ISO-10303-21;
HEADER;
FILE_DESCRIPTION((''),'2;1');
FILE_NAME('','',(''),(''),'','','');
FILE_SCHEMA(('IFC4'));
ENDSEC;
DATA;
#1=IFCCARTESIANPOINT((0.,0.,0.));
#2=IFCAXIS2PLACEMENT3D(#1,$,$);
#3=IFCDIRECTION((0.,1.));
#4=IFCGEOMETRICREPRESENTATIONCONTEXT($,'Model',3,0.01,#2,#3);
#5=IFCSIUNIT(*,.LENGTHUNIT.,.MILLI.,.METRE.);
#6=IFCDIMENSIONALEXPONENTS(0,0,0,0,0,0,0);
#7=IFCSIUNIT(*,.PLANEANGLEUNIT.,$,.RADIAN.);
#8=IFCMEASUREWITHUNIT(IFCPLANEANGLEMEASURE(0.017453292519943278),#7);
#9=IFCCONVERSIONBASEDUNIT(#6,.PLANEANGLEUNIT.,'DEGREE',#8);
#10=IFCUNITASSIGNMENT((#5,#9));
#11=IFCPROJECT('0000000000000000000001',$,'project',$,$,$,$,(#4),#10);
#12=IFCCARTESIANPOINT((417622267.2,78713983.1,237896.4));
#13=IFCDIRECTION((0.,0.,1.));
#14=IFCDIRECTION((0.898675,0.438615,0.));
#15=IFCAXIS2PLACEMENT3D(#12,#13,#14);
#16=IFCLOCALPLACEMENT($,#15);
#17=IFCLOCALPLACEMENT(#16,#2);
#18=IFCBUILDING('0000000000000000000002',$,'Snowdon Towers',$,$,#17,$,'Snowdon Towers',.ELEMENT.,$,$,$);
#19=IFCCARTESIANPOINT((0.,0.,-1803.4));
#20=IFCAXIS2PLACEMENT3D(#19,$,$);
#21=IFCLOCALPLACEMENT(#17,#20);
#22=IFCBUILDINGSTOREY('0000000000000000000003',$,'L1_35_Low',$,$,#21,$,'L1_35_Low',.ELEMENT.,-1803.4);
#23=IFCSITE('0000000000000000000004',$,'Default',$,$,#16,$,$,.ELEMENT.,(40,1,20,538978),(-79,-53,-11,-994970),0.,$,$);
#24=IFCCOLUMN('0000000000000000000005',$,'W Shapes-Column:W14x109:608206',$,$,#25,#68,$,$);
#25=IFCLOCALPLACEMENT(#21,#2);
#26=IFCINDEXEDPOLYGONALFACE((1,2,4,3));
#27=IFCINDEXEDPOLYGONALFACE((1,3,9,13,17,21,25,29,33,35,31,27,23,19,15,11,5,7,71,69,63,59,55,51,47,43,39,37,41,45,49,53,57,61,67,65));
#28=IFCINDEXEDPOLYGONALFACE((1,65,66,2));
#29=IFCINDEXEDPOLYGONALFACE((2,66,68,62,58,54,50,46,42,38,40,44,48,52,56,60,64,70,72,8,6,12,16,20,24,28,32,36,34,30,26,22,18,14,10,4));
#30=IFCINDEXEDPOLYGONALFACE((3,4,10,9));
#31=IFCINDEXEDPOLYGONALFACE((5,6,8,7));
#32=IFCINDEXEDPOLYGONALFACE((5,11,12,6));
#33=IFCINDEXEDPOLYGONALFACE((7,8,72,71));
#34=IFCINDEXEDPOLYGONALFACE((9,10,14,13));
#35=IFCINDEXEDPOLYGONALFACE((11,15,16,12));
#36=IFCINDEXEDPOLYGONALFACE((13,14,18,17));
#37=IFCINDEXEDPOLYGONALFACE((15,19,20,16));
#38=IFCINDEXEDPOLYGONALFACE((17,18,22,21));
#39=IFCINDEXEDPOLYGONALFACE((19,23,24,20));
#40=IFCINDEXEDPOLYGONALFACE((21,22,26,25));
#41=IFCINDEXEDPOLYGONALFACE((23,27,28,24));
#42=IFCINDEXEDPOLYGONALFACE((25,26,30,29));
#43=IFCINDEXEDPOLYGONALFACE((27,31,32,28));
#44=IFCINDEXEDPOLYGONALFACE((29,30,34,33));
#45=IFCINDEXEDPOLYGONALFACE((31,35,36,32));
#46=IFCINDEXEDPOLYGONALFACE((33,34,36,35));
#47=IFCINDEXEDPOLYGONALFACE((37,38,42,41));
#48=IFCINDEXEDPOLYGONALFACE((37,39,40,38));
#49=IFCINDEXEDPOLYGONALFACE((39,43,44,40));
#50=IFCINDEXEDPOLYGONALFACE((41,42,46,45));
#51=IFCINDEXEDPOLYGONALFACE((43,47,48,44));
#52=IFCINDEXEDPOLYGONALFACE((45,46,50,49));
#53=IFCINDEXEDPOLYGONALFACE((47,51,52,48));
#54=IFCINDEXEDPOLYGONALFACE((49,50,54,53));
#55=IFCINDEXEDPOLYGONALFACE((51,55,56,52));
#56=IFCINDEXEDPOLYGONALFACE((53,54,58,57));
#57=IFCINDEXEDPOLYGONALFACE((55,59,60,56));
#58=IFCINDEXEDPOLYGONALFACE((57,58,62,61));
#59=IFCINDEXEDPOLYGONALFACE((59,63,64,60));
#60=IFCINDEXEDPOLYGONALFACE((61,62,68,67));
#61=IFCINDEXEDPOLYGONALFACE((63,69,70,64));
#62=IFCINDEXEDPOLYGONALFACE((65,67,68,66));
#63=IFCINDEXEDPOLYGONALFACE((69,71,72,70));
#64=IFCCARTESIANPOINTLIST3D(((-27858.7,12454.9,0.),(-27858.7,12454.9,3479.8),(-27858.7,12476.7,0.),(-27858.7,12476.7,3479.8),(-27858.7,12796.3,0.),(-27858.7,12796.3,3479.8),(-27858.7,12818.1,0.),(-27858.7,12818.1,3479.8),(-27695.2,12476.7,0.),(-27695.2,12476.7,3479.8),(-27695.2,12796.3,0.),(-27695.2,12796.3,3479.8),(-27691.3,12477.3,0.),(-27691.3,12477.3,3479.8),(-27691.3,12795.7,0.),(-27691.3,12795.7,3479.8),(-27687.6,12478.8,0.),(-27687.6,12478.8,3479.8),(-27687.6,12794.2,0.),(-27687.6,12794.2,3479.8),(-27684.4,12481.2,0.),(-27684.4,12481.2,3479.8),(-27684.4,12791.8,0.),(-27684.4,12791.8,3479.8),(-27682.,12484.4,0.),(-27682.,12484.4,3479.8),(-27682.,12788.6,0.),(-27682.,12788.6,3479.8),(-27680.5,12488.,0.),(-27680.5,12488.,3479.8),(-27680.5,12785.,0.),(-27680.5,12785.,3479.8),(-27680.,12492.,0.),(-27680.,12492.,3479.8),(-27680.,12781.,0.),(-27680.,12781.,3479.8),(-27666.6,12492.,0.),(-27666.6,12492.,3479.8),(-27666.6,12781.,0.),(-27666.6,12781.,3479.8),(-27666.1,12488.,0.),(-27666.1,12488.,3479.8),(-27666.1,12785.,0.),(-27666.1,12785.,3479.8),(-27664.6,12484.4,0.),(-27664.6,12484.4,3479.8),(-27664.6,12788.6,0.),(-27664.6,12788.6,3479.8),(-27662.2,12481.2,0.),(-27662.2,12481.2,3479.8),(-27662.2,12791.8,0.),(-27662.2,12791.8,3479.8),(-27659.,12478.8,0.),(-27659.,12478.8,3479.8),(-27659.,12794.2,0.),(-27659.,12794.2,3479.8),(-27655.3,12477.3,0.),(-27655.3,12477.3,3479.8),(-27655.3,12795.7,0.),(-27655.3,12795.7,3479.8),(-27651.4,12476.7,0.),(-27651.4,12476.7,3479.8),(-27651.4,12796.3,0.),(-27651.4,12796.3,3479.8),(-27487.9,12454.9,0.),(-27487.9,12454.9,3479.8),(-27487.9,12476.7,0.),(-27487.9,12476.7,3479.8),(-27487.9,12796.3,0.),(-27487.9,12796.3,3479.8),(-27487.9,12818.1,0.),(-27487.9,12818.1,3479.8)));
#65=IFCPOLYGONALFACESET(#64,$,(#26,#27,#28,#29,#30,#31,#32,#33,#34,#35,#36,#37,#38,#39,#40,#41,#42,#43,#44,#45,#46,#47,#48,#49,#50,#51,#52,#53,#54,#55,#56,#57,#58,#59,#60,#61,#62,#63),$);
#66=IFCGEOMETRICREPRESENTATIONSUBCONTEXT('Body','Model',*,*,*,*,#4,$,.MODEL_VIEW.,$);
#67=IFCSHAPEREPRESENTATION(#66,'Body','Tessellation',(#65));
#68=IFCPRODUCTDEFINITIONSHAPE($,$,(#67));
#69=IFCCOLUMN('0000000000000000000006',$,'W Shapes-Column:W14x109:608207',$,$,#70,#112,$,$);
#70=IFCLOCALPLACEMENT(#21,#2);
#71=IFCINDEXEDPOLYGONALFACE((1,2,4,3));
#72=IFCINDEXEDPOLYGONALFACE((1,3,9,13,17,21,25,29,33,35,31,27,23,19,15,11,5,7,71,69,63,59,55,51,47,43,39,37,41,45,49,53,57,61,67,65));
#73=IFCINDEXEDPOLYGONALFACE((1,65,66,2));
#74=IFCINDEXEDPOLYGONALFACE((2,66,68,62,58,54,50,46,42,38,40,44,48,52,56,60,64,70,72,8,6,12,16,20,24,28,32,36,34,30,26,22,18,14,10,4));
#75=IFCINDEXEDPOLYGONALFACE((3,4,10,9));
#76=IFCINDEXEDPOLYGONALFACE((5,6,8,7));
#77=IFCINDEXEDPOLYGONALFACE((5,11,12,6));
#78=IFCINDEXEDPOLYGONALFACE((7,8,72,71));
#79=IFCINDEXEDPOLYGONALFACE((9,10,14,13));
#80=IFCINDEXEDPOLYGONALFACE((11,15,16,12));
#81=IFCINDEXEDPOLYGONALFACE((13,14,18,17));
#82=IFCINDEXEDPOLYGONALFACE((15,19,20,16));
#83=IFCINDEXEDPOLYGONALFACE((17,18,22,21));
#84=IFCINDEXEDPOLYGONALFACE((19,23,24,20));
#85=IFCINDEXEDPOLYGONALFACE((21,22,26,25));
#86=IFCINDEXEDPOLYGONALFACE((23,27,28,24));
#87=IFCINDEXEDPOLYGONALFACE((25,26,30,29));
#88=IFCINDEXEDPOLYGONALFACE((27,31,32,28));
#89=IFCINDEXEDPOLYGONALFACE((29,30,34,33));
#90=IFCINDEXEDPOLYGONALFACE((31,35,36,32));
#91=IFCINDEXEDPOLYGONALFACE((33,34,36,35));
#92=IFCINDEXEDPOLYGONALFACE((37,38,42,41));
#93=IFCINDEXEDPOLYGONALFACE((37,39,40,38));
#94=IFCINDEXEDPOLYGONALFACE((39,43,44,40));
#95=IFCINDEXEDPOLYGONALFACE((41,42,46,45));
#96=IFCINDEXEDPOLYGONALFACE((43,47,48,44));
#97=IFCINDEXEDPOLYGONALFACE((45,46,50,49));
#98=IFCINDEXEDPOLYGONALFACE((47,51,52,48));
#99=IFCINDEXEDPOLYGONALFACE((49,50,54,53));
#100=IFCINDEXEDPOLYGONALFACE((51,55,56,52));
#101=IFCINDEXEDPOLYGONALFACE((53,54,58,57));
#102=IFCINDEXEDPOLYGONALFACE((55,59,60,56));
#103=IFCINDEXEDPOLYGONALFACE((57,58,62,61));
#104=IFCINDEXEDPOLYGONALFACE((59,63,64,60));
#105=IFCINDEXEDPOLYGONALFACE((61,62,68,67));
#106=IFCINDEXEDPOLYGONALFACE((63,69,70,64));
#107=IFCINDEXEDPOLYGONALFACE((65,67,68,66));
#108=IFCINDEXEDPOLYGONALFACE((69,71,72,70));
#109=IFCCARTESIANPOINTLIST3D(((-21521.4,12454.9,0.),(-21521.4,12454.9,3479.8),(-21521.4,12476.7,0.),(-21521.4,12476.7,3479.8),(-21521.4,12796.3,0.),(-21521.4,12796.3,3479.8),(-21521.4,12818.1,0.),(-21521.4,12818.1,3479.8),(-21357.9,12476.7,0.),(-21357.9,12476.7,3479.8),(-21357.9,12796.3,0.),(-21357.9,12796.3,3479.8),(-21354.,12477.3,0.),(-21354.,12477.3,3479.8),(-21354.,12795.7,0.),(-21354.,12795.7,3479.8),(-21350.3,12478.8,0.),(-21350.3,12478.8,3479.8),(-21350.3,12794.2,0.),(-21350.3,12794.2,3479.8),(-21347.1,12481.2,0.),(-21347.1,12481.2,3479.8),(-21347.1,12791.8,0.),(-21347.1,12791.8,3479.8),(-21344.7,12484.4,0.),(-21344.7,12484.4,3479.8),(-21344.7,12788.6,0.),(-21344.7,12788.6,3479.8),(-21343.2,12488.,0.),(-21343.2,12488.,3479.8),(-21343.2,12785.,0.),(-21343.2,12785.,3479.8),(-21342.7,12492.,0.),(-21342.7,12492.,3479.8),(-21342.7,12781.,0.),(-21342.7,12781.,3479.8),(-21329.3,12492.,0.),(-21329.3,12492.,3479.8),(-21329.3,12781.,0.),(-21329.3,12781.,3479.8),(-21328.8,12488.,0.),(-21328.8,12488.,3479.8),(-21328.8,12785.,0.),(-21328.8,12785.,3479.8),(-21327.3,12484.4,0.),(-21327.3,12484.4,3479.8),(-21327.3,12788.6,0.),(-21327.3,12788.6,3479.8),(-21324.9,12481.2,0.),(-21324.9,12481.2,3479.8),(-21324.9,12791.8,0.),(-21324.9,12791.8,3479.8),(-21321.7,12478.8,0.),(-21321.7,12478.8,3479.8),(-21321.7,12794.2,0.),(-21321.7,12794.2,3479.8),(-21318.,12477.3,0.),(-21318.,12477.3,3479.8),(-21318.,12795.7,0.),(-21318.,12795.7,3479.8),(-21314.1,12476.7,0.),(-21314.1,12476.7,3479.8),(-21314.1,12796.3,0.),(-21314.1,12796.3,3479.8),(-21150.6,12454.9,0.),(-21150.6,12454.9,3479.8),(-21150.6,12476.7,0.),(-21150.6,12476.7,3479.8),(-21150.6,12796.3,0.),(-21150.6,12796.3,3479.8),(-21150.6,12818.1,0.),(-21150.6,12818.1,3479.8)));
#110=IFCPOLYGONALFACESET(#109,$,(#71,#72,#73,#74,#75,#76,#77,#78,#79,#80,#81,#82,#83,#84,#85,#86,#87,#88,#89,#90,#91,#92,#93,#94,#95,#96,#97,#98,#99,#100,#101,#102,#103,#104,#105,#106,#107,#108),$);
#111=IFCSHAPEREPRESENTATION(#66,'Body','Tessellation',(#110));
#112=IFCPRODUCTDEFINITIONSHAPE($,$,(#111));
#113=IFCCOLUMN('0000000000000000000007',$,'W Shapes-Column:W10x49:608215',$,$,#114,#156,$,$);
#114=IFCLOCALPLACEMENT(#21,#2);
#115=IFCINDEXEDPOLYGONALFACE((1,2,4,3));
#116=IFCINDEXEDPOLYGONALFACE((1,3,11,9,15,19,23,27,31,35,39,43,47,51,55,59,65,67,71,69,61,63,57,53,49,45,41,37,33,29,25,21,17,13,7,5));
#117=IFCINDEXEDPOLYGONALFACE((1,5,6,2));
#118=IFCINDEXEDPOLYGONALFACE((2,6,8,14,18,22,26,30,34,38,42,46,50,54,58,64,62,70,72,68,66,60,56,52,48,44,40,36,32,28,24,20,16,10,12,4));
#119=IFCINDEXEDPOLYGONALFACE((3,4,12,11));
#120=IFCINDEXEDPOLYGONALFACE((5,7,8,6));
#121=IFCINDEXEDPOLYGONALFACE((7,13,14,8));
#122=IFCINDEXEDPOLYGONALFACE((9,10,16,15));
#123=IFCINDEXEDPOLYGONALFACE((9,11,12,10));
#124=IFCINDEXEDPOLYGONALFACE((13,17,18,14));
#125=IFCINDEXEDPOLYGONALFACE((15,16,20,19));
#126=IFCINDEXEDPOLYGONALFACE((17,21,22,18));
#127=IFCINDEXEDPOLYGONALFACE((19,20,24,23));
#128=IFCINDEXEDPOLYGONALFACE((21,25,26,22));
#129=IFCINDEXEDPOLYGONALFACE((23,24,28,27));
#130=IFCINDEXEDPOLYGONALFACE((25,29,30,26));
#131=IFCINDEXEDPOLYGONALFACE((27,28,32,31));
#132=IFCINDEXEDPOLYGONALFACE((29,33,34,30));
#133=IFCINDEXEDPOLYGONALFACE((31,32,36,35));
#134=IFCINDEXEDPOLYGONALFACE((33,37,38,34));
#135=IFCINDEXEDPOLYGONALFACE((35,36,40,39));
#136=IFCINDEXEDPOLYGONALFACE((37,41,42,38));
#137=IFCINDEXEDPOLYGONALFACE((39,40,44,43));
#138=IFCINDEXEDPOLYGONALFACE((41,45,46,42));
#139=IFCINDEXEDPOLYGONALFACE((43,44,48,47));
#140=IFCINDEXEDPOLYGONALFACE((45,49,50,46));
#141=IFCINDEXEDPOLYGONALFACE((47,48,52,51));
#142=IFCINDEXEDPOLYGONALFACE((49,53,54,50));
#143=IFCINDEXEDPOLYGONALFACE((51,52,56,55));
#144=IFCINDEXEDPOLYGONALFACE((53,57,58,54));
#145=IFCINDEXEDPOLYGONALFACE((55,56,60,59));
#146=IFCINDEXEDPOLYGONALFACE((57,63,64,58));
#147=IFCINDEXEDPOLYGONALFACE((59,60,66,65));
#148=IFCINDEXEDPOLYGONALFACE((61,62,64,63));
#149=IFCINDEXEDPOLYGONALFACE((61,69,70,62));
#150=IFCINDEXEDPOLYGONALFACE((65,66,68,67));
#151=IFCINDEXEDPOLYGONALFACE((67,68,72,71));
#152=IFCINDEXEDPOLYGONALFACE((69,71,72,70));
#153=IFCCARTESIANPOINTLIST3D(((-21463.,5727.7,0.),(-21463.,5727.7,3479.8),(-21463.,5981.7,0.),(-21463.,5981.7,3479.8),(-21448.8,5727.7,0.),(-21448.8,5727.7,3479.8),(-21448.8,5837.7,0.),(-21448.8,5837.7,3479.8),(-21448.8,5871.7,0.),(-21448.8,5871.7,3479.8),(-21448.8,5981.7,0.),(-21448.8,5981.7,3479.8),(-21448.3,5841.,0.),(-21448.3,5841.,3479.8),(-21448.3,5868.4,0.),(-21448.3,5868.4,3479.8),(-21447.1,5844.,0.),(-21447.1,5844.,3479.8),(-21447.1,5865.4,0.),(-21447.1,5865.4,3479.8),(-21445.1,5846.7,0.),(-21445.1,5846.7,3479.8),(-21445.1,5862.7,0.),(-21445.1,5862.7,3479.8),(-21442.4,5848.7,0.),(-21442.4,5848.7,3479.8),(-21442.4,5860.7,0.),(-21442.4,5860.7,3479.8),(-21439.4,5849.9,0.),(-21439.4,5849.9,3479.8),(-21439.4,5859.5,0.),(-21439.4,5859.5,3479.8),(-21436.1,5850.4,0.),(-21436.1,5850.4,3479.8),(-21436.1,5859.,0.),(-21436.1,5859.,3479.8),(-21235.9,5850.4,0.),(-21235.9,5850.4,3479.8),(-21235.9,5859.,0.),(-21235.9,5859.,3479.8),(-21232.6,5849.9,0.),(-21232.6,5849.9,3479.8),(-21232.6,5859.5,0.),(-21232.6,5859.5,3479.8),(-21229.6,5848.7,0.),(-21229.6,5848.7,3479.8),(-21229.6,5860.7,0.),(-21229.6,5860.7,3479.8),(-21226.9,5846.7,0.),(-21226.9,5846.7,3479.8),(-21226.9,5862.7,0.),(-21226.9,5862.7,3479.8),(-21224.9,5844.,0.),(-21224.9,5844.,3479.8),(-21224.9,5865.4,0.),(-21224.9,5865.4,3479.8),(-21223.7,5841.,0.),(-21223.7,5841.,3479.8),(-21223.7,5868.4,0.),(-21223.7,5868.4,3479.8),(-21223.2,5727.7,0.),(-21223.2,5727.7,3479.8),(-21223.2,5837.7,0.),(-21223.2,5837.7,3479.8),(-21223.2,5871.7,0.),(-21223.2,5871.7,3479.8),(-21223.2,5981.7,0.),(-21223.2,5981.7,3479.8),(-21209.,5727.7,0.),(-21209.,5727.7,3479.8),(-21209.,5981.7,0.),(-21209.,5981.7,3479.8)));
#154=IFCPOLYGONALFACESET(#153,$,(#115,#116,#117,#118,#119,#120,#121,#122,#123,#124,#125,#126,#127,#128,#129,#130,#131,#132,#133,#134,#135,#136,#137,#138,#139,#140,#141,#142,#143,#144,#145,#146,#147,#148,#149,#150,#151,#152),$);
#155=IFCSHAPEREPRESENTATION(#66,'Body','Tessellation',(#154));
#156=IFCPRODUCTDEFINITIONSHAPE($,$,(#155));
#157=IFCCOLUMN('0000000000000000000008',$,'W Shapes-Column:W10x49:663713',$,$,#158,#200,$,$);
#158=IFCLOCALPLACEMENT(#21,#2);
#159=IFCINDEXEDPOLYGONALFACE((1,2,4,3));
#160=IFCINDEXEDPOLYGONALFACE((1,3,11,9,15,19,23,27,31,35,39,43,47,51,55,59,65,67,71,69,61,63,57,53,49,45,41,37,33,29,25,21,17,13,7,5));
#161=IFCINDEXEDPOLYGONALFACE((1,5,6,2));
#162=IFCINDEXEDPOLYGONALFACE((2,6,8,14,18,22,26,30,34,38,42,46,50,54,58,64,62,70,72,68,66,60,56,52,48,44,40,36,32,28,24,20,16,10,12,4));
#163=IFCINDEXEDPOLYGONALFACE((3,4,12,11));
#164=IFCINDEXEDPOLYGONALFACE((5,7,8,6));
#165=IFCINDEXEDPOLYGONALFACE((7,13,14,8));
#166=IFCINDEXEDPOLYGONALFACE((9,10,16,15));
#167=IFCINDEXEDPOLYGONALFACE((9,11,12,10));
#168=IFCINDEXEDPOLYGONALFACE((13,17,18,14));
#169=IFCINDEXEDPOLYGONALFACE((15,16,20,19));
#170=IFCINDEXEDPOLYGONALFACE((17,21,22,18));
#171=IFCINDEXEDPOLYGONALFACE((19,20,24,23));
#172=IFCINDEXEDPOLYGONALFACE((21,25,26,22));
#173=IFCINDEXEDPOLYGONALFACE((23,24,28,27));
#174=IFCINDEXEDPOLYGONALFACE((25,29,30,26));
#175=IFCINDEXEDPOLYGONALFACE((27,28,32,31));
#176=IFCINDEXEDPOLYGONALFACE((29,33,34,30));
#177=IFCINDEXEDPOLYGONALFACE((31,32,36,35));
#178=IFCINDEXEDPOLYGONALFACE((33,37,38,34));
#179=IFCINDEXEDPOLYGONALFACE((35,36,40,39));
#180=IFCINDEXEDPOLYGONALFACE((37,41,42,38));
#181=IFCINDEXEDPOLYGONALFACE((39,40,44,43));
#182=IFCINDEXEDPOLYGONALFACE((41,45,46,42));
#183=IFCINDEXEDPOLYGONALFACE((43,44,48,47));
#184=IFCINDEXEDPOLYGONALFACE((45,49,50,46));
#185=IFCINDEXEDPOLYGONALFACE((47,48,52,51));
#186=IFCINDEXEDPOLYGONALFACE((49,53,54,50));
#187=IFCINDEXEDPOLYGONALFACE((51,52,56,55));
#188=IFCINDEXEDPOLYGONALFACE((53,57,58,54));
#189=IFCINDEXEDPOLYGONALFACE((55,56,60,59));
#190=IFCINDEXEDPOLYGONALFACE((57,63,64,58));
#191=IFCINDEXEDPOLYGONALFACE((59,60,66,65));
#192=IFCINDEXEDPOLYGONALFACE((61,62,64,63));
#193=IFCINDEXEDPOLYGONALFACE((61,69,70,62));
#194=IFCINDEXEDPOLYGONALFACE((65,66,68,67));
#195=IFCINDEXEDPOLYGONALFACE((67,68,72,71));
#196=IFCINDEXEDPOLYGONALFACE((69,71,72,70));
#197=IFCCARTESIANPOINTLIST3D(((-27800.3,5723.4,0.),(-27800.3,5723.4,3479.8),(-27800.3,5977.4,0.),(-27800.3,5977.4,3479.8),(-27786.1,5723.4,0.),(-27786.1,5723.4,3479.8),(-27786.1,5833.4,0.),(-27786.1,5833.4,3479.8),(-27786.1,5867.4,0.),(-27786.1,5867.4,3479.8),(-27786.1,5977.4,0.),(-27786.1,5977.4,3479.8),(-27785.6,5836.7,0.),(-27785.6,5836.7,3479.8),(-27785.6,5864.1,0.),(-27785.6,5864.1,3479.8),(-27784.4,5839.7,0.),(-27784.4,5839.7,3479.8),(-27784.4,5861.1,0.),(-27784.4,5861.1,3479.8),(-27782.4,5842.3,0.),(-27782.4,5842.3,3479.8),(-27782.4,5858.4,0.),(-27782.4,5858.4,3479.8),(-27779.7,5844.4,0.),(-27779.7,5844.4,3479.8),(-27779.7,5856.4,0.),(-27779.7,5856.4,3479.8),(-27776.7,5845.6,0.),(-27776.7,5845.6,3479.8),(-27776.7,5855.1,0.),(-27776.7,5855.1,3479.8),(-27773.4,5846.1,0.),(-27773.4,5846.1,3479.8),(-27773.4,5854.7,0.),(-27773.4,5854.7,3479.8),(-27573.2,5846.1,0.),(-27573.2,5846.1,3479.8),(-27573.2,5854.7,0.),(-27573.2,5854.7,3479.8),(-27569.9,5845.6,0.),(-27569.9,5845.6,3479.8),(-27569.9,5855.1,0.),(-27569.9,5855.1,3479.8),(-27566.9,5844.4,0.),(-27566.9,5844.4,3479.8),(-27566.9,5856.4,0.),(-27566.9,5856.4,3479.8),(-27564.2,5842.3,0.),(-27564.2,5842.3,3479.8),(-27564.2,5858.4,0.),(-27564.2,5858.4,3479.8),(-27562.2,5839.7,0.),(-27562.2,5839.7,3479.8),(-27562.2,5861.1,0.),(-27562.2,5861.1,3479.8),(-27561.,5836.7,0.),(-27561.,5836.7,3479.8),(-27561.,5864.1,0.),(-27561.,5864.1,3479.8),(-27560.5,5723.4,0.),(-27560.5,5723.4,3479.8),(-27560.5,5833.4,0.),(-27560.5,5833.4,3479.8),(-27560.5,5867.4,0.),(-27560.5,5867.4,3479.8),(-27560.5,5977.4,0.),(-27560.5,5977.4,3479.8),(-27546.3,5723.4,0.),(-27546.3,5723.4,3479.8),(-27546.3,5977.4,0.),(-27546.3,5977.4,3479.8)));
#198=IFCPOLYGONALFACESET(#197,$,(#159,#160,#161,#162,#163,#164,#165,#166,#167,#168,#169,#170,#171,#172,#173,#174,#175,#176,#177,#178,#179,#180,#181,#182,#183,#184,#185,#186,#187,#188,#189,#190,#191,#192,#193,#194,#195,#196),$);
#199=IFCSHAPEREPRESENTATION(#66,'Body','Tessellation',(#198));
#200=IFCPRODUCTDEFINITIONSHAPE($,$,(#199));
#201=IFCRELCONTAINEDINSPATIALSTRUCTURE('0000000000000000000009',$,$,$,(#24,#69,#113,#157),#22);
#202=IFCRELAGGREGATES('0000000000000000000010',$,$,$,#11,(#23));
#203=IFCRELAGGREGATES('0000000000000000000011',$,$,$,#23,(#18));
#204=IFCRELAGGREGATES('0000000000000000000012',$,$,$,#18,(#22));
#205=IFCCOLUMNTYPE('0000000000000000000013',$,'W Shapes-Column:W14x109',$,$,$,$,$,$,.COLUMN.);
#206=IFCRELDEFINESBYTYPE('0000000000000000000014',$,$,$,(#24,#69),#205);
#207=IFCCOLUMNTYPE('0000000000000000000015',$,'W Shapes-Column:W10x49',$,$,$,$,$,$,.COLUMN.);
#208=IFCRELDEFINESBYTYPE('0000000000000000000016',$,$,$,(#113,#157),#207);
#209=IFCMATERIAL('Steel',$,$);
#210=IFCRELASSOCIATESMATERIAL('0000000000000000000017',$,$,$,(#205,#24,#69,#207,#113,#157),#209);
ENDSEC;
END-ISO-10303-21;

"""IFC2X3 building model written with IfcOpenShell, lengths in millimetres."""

from ifc_helpers import new_model, entity, si_unit, converted_unit, direction, frame, frame_2d, origin, place, context, subcontext, project, spatial, i_section, extrude, source, transform, mapped, material, type_object, type_shapes, element, save


model = new_model("IFC2X3")

# Units and contexts
model_context = context("Model", 3, precision=0.01, world=origin(), true_north=direction((0.0, 1.0)))
body_context = subcontext(model_context, "Body", "Model", "MODEL_VIEW")
ifc_project = project(units=[si_unit("LENGTHUNIT", "METRE", prefix="MILLI"), converted_unit("PLANEANGLEUNIT", "DEGREE", entity("IfcPlaneAngleMeasure", 0.017453292519943278), si_unit("PLANEANGLEUNIT", "RADIAN"), dimensions=[0, 0, 0, 0, 0, 0, 0])], contexts=[model_context])

# Site, building, storey
site_placement = place(None, frame((417622267.2, 78713983.1, 237896.4), z_axis=(0.0, 0.0, 1.0), x_axis=(0.898675, 0.438615, 0.0)))
site = spatial("IfcSite", under=ifc_project, at=site_placement, Name="Default", CompositionType="ELEMENT", RefLatitude=(40, 1, 20, 538978), RefLongitude=(-79, -53, -11, -994970), RefElevation=0.0)
building_placement = place(site_placement, origin())
building = spatial("IfcBuilding", under=site, at=building_placement, Name="Snowdon Towers", LongName="Snowdon Towers", CompositionType="ELEMENT")
storey_placement = place(building_placement, frame((0.0, 0.0, -1803.4)))
storey = spatial("IfcBuildingStorey", under=building, at=storey_placement, Name="L1_35_Low", LongName="L1_35_Low", CompositionType="ELEMENT", Elevation=-1803.4)

# Columns
ifc_material_1 = material(Name="Steel")
column_type_1 = type_object("IfcColumnType", Name="W Shapes-Column:W14x109", PredefinedType="COLUMN", material=ifc_material_1)
shared_shape_1 = source(origin(), body_context, "Body", "SweptSolid", [
    extrude(i_section(OverallWidth=370.8, OverallDepth=363.2, WebThickness=13.3, FlangeThickness=21.8, FilletRadius=15.2, at=frame_2d((0.0, 0.0), x_axis=(1.0, 0.0))), frame((0.0, 0.0, -1803.4), z_axis=(0.0, 0.0, 1.0), x_axis=(-1.0, 0.0, 0.0)), (0.0, 0.0, 1.0), 3479.8),
])
type_shapes(column_type_1, [shared_shape_1])
for number, where, z_axis, x_axis, name in (
    (1, (-27673.3, 12636.5, 1803.4), (0.0, 0.0, 1.0), (-1.0, 0.0, 0.0), "W Shapes-Column:W14x109:608206"),
    (2, (-21336.0, 12636.5, 1803.4), (0.0, 0.0, 1.0), (-1.0, 0.0, 0.0), "W Shapes-Column:W14x109:608207"),
):
    element("IfcColumn", number, at=place(storey_placement, frame(where, z_axis=z_axis, x_axis=x_axis)), inside=storey, type_object=column_type_1, material=ifc_material_1, Name=name, context=body_context, shape_type="MappedRepresentation", body=[
        mapped(shared_shape_1, transform((0.0, 0.0, 0.0), scale=1.0)),
    ])
column_type_2 = type_object("IfcColumnType", Name="W Shapes-Column:W10x49", PredefinedType="COLUMN", material=ifc_material_1)
shared_shape_2 = source(origin(), body_context, "Body", "SweptSolid", [
    extrude(i_section(OverallWidth=254.0, OverallDepth=254.0, WebThickness=8.6, FlangeThickness=14.2, FilletRadius=12.7, at=frame_2d((0.0, 0.0), x_axis=(1.0, 0.0))), frame((0.0, 0.0, -1803.4), z_axis=(0.0, 0.0, 1.0), x_axis=(-1.0, 0.0, 0.0)), (0.0, 0.0, 1.0), 3479.8),
])
type_shapes(column_type_2, [shared_shape_2])
for number, where, z_axis, x_axis, name in (
    (3, (-21336.0, 5854.7, 1803.4), (0.0, 0.0, 1.0), (0.0, 1.0, 0.0), "W Shapes-Column:W10x49:608215"),
    (4, (-27673.3, 5850.4, 1803.4), (0.0, 0.0, 1.0), (0.0, 1.0, 0.0), "W Shapes-Column:W10x49:663713"),
):
    element("IfcColumn", number, at=place(storey_placement, frame(where, z_axis=z_axis, x_axis=x_axis)), inside=storey, type_object=column_type_2, material=ifc_material_1, Name=name, context=body_context, shape_type="MappedRepresentation", body=[
        mapped(shared_shape_2, transform((0.0, 0.0, 0.0), scale=1.0)),
    ])

save(model, "model.ifc")
